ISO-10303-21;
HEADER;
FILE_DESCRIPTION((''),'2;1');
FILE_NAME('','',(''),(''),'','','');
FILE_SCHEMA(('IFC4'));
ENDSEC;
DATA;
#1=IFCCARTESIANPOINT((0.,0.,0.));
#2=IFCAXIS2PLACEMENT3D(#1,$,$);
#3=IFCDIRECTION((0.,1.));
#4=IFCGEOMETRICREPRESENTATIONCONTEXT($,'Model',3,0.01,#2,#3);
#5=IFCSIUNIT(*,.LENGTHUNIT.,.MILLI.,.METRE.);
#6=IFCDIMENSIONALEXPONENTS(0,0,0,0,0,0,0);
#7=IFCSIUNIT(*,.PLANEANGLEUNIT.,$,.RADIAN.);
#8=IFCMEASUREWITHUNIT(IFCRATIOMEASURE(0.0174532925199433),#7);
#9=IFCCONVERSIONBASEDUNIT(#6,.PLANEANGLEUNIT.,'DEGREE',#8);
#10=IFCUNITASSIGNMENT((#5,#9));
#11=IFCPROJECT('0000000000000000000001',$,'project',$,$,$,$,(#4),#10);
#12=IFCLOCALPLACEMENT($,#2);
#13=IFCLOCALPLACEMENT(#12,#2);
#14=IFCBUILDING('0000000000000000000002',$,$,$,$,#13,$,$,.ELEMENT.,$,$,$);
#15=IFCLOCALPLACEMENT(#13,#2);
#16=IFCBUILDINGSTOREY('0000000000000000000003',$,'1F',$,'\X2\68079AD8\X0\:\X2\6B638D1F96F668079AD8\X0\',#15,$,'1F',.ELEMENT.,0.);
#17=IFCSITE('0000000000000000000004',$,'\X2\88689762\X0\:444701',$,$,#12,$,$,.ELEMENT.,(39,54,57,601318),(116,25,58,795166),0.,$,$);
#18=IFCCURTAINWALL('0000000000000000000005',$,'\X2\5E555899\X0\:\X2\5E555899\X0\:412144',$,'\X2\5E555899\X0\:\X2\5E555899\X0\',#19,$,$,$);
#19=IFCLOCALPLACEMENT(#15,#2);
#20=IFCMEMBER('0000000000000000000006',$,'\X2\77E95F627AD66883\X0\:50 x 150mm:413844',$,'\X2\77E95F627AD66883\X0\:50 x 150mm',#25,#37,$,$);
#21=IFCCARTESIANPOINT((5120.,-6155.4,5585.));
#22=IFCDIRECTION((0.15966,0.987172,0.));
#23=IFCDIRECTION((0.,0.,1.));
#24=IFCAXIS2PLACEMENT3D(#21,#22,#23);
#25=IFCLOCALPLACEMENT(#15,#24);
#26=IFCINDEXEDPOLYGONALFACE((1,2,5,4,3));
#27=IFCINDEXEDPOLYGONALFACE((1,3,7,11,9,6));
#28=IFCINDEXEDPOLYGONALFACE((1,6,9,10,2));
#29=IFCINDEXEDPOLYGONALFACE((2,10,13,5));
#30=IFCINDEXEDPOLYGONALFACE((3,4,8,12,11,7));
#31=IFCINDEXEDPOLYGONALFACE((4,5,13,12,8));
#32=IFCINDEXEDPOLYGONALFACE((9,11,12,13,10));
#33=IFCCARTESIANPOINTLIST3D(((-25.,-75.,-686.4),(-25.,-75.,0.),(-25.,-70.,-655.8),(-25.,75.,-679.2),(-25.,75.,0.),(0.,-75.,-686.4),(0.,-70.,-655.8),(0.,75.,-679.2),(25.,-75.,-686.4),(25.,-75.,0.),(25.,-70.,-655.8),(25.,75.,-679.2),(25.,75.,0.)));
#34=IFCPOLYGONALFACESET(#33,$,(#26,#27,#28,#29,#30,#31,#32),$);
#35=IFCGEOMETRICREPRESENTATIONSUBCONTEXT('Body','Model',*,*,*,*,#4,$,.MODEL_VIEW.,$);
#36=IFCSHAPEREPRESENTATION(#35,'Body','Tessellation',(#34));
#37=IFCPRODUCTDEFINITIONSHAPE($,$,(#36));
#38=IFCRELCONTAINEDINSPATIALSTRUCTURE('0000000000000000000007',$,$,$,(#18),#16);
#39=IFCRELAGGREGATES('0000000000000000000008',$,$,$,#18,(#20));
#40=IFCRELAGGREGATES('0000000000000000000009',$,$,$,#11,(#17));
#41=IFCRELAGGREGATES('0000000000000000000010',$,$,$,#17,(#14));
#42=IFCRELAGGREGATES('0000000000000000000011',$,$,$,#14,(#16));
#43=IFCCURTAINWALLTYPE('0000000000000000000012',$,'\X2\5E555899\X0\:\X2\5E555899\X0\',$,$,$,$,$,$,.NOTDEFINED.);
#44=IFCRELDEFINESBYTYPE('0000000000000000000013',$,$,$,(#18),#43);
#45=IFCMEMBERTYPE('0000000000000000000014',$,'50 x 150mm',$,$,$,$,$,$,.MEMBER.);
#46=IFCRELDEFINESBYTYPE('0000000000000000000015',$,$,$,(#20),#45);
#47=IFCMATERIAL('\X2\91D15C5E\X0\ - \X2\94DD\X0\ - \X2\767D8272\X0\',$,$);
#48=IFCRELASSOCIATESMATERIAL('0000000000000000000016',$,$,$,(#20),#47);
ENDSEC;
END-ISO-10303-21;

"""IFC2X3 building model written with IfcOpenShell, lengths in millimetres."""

from ifc_helpers import new_model, entity, si_unit, converted_unit, direction, frame, frame_2d, origin, place, context, subcontext, project, spatial, polyline, rectangle, extrude, clip, bounded_halfspace, source, transform, mapped, material, type_object, type_shapes, element, aggregate, save


model = new_model("IFC2X3")

# Units and contexts
model_context = context("Model", 3, precision=0.01, world=origin(), true_north=direction((0.0, 1.0)))
body_context = subcontext(model_context, "Body", "Model", "MODEL_VIEW")
ifc_project = project(units=[si_unit("LENGTHUNIT", "METRE", prefix="MILLI"), converted_unit("PLANEANGLEUNIT", "DEGREE", entity("IfcRatioMeasure", 0.0174532925199433), si_unit("PLANEANGLEUNIT", "RADIAN"), dimensions=[0, 0, 0, 0, 0, 0, 0])], contexts=[model_context])

# Site, building, storey
site_placement = place(None, origin())
site = spatial("IfcSite", under=ifc_project, at=site_placement, Name="表面:444701", CompositionType="ELEMENT", RefLatitude=(39, 54, 57, 601318), RefLongitude=(116, 25, 58, 795166), RefElevation=0.0)
building_placement = place(site_placement, origin())
building = spatial("IfcBuilding", under=site, at=building_placement, CompositionType="ELEMENT")
storey_placement = place(building_placement, origin())
storey = spatial("IfcBuildingStorey", under=building, at=storey_placement, Name="1F", ObjectType="标高:正负零标高", LongName="1F", CompositionType="ELEMENT", Elevation=0.0)

# Curtain wall, member
curtain_wall_type = type_object("IfcCurtainWallType", Name="幕墙:幕墙", PredefinedType="NOTDEFINED")
curtain_wall_1_placement = place(storey_placement, origin())
curtain_wall_1 = element("IfcCurtainWall", 1, at=curtain_wall_1_placement, inside=storey, type_object=curtain_wall_type, Name="幕墙:幕墙:412144", ObjectType="幕墙:幕墙")
ifc_material_1 = material(Name="金属 - 铝 - 白色")
member_type_1 = type_object("IfcMemberType", Name="50 x 150mm", PredefinedType="MEMBER")
shared_shape_1 = source(origin(), body_context, "Body", "Clipping", [
    clip(clip(clip(clip(extrude(rectangle(XDim=150.0, YDim=50.0, at=frame_2d((0.0, 0.0), x_axis=(1.0, 0.0))), frame((0.0, 0.0, -686.4), z_axis=(0.0, 0.0, 1.0), x_axis=(0.0, -1.0, 0.0)), (0.0, 0.0, 1.0), 686.4), bounded_halfspace(frame((-1390.0, -70.0, -655.8), z_axis=(0.0, -0.15966, -0.987172), x_axis=(1.0, 0.0, 0.0)), False, frame((0.0, 0.0, -686.4), z_axis=(0.0, 0.0, 1.0), x_axis=(0.0, -1.0, 0.0)), polyline([(70.0, -25.0), (-75.0, -25.0), (-75.0, 0.0), (70.0, 0.0), (70.0, -25.0)]))), bounded_halfspace(frame((0.0, -70.0, -655.8), z_axis=(0.0, -0.15966, -0.987172), x_axis=(1.0, 0.0, 0.0)), False, frame((0.0, 0.0, -686.4), z_axis=(0.0, 0.0, 1.0), x_axis=(0.0, -1.0, 0.0)), polyline([(-75.0, 25.0), (70.0, 25.0), (70.0, 0.0), (-75.0, 0.0), (-75.0, 25.0)]))), bounded_halfspace(frame((-1390.0, -78.0, -705.1), z_axis=(0.0, 0.987172, -0.15966), x_axis=(1.0, 0.0, 0.0)), False, frame((0.0, 0.0, -686.4), z_axis=(0.0, 0.0, 1.0), x_axis=(0.0, -1.0, 0.0)), polyline([(75.0, 0.0), (75.0, -25.0), (70.0, -25.0), (70.0, 0.0), (75.0, 0.0)]))), bounded_halfspace(frame((0.0, -78.0, -705.1), z_axis=(0.0, 0.987172, -0.15966), x_axis=(1.0, 0.0, 0.0)), False, frame((0.0, 0.0, -686.4), z_axis=(0.0, 0.0, 1.0), x_axis=(0.0, -1.0, 0.0)), polyline([(70.0, 25.0), (75.0, 25.0), (75.0, 0.0), (70.0, 0.0), (70.0, 25.0)]))),
])
type_shapes(member_type_1, [shared_shape_1])
member_1_placement = place(storey_placement, frame((5120.0, -6155.4, 5585.0), z_axis=(0.15966, 0.987172, 0.0), x_axis=(0.0, 0.0, 1.0)))
member_1 = element("IfcMember", 2, at=member_1_placement, type_object=member_type_1, material=ifc_material_1, Name="矩形竖梃:50 x 150mm:413844", ObjectType="矩形竖梃:50 x 150mm", context=body_context, shape_type="MappedRepresentation", body=[
    mapped(shared_shape_1, transform((0.0, 0.0, 0.0), scale=1.0)),
])
aggregate(curtain_wall_1, [member_1])

save(model, "model.ifc")
